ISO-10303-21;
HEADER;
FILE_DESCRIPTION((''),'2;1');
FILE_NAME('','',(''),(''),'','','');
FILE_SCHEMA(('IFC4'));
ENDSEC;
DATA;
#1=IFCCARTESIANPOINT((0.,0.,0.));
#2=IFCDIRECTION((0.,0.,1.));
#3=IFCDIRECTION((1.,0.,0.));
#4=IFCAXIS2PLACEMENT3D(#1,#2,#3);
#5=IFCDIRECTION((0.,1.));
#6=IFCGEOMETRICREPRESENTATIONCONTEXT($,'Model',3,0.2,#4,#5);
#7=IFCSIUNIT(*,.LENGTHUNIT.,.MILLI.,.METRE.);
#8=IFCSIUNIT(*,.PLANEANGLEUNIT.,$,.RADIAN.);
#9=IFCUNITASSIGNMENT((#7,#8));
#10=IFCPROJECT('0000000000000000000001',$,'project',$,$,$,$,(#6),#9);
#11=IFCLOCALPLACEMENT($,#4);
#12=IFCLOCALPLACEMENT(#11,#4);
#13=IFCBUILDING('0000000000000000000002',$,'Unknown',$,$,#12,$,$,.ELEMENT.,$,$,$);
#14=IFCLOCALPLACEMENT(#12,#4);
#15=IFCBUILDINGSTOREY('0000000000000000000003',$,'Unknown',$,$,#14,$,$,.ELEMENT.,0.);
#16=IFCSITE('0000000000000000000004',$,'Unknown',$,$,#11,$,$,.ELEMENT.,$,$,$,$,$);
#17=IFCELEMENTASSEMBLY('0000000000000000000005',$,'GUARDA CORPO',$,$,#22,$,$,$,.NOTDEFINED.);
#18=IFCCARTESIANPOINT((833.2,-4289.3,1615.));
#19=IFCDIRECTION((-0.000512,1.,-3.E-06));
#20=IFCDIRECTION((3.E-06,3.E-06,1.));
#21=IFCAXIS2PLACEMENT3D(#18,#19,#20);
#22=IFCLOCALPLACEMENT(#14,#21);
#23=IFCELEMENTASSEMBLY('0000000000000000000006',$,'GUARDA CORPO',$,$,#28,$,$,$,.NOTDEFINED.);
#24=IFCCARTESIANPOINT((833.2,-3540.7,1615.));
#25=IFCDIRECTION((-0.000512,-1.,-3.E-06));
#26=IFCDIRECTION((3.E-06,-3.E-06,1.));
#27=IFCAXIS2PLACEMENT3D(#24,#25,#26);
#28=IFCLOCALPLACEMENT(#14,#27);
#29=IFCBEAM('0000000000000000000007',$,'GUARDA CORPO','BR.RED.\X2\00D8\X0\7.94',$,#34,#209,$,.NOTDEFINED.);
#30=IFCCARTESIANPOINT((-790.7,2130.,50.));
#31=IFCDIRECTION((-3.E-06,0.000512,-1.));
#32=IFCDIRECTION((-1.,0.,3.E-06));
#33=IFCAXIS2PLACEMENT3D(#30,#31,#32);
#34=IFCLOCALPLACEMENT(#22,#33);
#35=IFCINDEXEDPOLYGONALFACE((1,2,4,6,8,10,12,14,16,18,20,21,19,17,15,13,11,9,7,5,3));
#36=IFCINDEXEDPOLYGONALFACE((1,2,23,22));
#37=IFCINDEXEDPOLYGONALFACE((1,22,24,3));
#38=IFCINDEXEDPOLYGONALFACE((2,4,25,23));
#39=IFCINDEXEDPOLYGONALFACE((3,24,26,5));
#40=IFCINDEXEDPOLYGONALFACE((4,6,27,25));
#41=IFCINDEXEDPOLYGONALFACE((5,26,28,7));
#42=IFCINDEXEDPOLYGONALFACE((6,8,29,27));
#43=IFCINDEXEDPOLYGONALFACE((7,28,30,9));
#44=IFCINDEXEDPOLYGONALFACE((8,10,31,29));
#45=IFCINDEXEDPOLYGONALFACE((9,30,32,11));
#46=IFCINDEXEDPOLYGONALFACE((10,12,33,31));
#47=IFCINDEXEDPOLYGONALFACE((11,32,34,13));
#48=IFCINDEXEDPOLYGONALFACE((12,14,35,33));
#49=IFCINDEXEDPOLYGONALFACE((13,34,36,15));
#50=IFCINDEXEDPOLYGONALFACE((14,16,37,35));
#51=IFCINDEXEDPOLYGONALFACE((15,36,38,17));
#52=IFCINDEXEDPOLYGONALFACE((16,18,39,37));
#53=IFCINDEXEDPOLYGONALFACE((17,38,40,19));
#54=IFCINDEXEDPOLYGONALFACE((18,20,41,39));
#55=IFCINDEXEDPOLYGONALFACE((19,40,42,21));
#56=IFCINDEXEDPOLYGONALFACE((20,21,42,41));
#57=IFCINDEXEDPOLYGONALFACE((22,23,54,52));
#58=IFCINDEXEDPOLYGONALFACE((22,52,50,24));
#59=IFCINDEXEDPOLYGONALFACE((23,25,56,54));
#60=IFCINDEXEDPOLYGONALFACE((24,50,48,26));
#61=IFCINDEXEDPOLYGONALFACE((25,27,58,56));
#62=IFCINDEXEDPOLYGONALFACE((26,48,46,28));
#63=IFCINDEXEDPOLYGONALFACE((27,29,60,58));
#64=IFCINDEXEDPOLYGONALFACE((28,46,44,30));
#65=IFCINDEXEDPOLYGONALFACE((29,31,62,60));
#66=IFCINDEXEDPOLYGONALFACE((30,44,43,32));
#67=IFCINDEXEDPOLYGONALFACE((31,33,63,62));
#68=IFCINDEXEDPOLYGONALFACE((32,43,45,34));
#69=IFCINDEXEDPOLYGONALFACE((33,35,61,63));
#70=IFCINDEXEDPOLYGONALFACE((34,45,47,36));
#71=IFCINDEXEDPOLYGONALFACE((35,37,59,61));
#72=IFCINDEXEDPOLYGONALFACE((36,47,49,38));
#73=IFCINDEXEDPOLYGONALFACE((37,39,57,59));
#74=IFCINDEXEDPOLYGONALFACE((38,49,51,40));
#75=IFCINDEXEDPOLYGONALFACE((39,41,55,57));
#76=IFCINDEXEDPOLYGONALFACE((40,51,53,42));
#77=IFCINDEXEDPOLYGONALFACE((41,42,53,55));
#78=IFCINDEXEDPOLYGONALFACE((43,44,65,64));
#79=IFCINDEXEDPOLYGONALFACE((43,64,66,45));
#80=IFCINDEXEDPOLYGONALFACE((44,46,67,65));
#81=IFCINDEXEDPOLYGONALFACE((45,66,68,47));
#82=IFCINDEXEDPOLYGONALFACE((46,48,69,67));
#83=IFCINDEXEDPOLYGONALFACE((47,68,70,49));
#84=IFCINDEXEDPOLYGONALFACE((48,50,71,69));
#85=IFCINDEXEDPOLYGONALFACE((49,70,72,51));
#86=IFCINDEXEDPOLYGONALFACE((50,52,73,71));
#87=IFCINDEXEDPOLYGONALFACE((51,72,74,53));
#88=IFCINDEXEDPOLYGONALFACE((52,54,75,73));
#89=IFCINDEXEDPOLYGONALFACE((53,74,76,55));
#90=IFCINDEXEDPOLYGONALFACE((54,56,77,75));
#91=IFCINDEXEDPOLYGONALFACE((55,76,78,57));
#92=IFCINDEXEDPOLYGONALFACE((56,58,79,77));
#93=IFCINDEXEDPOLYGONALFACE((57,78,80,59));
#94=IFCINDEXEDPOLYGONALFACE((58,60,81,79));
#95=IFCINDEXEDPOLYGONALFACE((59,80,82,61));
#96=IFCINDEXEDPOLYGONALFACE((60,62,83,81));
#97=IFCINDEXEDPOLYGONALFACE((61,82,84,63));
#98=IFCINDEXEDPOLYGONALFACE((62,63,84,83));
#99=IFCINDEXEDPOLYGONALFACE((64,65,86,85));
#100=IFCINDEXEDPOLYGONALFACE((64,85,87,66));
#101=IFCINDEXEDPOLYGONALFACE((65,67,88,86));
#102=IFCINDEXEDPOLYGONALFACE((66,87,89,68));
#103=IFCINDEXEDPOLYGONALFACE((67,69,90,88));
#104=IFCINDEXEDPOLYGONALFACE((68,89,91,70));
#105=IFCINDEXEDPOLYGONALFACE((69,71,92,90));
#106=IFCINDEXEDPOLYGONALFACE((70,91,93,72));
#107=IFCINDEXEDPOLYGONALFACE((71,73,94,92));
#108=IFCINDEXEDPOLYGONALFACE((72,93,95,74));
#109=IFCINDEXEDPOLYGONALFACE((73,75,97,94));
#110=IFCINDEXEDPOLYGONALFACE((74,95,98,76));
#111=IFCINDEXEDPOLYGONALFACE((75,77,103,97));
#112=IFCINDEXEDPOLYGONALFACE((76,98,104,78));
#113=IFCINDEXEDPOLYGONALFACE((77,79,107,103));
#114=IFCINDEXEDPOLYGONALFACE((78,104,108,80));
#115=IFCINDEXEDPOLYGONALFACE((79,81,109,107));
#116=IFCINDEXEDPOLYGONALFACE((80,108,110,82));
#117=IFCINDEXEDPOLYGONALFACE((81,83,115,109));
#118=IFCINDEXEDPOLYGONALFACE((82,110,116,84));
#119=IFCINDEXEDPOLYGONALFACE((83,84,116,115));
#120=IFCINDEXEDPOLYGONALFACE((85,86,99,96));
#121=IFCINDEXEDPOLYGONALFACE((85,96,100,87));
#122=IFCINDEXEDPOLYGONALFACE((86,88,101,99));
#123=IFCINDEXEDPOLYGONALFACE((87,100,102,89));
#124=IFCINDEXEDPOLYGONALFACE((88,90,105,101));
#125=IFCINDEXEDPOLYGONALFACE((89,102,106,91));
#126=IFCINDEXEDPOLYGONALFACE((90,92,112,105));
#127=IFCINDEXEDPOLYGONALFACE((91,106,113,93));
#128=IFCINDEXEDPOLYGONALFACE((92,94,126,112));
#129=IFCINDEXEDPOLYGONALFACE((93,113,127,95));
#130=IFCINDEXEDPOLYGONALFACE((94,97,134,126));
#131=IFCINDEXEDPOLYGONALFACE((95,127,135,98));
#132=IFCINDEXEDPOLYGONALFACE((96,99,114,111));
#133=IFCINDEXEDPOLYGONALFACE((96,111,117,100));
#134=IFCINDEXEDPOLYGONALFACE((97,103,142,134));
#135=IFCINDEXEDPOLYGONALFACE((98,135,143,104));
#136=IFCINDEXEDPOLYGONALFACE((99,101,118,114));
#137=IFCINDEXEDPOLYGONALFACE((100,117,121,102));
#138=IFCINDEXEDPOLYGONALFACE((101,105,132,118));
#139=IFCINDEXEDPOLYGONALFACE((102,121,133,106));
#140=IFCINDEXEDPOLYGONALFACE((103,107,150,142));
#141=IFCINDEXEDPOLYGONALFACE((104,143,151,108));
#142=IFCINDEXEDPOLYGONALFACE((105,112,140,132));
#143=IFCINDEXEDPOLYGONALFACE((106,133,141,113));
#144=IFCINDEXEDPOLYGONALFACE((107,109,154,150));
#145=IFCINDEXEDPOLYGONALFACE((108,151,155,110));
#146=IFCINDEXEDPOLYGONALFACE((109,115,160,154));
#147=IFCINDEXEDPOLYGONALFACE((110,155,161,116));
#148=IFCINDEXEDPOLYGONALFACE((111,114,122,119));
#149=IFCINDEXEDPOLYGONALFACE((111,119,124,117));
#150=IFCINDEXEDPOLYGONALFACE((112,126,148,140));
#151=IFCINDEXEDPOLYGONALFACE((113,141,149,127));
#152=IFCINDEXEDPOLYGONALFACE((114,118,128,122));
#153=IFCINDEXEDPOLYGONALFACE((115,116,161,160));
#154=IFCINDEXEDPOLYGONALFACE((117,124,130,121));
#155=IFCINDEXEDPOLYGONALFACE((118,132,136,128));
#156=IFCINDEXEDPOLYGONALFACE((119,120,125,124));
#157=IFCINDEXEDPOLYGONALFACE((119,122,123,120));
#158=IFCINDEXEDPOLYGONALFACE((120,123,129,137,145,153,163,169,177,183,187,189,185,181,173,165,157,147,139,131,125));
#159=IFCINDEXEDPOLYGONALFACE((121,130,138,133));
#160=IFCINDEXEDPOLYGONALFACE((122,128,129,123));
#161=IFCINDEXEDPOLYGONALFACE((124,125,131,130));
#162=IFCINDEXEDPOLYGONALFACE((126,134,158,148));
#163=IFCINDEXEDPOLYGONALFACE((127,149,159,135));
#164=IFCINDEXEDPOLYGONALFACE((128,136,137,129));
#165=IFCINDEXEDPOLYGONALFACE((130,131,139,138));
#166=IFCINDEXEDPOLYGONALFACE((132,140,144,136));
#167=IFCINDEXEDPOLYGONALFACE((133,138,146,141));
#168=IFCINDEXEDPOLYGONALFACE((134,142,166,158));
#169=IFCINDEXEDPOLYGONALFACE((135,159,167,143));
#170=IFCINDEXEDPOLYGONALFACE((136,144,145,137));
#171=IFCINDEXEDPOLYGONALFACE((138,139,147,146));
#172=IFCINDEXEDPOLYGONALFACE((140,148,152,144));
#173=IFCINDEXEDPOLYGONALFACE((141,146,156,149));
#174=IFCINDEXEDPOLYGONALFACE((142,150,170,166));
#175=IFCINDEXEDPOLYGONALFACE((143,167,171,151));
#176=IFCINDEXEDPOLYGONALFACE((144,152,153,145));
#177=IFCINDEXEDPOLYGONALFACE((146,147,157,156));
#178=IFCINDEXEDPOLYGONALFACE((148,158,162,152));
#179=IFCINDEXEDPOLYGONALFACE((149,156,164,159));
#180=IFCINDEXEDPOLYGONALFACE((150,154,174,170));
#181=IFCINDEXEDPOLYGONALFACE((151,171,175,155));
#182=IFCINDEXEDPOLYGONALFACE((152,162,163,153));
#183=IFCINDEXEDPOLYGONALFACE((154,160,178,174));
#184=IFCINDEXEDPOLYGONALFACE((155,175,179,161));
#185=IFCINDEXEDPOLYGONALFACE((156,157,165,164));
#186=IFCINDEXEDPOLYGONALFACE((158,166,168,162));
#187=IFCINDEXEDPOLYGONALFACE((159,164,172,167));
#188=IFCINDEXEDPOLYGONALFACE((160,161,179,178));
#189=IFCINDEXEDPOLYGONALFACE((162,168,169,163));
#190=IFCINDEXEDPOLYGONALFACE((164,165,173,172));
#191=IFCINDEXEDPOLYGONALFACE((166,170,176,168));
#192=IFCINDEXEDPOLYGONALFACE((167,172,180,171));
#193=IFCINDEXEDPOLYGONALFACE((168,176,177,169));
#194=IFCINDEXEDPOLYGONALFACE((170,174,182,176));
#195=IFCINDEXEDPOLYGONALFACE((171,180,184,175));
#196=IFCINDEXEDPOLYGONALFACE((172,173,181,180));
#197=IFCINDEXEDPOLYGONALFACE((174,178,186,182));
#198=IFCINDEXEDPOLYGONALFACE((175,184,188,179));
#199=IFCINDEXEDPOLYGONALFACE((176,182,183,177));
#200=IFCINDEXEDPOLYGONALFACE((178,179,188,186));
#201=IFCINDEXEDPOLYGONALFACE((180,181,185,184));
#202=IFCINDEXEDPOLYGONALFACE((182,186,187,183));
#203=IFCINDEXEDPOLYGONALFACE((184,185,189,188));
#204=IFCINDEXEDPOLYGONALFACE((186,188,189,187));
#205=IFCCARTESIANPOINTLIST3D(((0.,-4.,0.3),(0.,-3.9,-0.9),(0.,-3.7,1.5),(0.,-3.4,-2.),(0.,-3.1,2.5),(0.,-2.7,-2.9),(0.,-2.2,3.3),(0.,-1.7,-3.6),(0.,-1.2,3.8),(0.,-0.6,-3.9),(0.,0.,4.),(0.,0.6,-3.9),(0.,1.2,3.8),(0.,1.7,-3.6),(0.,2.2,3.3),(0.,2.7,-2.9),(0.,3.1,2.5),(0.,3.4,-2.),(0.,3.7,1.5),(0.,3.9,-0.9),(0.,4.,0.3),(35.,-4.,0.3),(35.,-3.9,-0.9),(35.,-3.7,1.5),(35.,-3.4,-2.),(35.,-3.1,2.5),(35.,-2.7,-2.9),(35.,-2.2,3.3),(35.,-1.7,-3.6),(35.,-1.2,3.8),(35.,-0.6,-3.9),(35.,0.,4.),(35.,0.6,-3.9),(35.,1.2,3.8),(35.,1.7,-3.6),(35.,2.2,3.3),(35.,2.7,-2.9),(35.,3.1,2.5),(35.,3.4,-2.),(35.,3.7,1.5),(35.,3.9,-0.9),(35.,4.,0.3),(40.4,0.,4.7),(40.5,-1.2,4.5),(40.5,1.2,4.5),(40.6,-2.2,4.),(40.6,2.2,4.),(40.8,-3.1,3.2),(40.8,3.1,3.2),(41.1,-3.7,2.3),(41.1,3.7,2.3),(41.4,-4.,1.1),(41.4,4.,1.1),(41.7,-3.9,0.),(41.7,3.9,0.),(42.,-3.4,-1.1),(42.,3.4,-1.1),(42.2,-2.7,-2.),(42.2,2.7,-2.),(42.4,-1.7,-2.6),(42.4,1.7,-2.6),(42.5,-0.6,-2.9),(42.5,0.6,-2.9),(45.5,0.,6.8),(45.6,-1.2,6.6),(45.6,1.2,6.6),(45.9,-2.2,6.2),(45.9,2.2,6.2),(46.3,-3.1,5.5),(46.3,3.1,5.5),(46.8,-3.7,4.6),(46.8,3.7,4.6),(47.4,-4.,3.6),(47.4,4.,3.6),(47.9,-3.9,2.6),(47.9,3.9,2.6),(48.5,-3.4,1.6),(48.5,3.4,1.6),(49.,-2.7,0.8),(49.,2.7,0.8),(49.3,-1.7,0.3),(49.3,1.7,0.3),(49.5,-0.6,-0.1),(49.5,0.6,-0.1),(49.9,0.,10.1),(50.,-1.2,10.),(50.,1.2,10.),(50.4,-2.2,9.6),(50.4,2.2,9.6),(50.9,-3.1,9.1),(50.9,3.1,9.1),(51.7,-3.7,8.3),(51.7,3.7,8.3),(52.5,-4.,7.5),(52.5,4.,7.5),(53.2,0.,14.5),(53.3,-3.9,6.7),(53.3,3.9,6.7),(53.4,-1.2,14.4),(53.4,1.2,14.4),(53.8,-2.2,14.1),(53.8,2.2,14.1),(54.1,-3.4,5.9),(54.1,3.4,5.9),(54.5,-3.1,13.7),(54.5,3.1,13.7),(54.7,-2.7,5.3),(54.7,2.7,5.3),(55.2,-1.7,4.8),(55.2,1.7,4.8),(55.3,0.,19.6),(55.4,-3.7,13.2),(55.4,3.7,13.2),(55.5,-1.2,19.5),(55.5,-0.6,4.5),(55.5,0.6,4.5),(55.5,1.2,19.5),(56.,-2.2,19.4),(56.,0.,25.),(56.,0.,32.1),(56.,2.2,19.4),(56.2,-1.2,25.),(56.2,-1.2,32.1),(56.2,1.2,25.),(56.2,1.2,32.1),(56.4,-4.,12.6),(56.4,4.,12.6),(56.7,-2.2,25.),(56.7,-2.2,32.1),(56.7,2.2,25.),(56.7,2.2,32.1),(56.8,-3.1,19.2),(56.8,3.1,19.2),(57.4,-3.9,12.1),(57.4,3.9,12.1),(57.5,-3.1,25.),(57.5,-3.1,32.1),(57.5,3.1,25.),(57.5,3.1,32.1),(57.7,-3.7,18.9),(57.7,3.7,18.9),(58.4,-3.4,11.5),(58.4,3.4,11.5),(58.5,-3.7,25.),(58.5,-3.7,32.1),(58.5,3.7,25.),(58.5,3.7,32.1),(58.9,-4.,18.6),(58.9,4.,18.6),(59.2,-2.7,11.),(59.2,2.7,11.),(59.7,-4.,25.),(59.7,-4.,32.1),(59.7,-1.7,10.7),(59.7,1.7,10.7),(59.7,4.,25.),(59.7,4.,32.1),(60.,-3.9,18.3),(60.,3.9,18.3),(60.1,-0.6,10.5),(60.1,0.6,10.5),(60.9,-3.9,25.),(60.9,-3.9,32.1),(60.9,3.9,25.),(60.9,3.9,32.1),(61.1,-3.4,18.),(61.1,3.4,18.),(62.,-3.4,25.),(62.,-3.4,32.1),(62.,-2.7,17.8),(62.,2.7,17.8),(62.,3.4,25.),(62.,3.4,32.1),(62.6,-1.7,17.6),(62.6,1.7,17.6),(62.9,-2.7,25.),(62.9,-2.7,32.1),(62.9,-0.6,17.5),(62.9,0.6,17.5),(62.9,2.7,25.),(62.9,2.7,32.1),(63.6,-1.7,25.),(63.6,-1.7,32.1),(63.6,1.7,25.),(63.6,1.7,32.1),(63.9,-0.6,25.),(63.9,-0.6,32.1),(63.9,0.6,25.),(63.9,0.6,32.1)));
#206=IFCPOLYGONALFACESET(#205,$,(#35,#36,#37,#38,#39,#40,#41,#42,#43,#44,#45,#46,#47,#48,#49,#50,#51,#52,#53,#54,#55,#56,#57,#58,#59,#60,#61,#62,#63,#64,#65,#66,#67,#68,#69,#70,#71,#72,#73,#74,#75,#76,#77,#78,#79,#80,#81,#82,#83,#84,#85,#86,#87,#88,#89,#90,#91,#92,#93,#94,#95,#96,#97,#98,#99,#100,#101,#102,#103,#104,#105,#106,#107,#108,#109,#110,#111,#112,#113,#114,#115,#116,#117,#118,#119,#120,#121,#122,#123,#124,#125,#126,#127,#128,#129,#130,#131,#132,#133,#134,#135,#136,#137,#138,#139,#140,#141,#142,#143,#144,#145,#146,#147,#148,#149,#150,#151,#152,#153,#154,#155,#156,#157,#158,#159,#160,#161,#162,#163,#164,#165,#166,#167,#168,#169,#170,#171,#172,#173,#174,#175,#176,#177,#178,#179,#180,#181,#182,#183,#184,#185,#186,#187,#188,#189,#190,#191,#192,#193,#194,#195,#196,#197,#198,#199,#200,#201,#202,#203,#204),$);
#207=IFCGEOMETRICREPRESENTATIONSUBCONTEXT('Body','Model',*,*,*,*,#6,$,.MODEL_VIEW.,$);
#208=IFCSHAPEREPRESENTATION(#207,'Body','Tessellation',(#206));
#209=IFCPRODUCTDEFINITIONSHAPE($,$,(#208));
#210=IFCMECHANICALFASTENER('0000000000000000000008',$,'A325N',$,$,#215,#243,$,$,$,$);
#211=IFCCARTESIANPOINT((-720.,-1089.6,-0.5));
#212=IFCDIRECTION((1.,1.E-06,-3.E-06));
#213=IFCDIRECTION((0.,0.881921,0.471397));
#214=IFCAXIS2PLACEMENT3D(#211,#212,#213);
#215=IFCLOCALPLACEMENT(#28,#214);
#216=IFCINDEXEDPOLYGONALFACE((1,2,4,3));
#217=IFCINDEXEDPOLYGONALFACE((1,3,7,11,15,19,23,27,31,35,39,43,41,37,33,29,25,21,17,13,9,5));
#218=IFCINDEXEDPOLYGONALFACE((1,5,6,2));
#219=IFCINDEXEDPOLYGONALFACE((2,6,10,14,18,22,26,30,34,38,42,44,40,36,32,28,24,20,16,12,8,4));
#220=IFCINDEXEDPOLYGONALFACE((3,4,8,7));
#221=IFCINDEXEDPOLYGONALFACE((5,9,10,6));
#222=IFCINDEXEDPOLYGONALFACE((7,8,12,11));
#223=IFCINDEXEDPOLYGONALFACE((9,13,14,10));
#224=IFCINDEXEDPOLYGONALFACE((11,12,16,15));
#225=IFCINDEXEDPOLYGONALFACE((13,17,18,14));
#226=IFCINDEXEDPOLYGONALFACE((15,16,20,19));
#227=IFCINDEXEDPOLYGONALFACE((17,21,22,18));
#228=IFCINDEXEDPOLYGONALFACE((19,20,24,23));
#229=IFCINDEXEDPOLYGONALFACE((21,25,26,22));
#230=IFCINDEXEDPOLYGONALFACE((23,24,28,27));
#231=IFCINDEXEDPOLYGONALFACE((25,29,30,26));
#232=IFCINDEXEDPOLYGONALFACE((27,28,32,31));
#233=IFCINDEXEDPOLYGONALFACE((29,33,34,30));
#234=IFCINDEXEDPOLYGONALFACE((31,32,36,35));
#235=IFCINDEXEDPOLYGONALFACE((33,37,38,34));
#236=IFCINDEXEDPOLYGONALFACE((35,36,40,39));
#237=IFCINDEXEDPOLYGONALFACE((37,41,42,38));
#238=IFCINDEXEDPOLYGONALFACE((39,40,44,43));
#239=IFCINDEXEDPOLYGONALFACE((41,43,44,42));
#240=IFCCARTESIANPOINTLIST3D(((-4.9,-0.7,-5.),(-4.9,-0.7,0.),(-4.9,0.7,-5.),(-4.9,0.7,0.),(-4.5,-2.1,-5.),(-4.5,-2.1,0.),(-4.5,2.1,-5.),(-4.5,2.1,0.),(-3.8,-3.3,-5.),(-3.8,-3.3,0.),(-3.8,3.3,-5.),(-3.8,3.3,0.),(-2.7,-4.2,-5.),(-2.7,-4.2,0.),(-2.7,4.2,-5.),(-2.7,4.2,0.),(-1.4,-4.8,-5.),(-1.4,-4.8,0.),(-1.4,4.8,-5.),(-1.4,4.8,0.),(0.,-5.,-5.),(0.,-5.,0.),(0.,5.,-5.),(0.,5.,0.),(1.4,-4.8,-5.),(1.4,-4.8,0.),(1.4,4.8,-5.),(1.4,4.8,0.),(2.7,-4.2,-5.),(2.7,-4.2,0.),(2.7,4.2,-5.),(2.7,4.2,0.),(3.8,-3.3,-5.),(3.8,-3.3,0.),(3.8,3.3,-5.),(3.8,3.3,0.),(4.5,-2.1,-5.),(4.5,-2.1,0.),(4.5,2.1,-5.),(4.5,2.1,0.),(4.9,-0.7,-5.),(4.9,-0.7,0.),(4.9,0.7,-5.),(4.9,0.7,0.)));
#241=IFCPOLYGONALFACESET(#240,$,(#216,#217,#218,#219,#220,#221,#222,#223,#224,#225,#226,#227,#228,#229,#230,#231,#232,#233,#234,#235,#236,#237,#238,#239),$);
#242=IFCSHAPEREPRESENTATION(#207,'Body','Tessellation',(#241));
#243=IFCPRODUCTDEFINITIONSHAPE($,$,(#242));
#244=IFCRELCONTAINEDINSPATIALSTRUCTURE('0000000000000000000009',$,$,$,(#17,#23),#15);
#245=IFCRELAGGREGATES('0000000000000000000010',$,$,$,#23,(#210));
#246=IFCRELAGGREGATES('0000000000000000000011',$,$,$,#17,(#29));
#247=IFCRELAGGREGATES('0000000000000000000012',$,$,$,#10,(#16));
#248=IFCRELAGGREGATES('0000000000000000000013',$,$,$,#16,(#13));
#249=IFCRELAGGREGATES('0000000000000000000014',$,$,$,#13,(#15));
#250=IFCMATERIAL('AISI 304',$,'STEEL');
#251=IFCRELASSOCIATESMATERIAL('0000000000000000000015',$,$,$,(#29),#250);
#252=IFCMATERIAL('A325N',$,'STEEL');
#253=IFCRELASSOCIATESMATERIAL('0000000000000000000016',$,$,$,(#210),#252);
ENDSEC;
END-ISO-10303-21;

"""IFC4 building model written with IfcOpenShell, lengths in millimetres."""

from ifc_helpers import new_model, entity, si_unit, direction, frame, origin_with_axes, place, context, subcontext, project, spatial, arc, indexed_curve, outline, extrude, source, transform, mapped, material, element, aggregate, save


model = new_model("IFC4")

# Units and contexts
model_context = context("Model", 3, precision=0.2, world=origin_with_axes(), true_north=direction((0.0, 1.0)))
body_context = subcontext(model_context, "Body", "Model", "MODEL_VIEW")
ifc_project = project(units=[si_unit("LENGTHUNIT", "METRE", prefix="MILLI"), si_unit("PLANEANGLEUNIT", "RADIAN")], contexts=[model_context])

# Site, building, storey
site_placement = place(None, origin_with_axes())
site = spatial("IfcSite", under=ifc_project, at=site_placement, Name="Unknown", CompositionType="ELEMENT")
building_placement = place(site_placement, origin_with_axes())
building = spatial("IfcBuilding", under=site, at=building_placement, Name="Unknown", CompositionType="ELEMENT")
storey_placement = place(building_placement, origin_with_axes())
storey = spatial("IfcBuildingStorey", under=building, at=storey_placement, Name="Unknown", CompositionType="ELEMENT", Elevation=0.0)

# Element assembly
assembly_1_placement = place(storey_placement, frame((833.2, -4289.3, 1615.0), z_axis=(-0.000512, 1.0, -0.000003), x_axis=(0.000003, 0.000003, 1.0)))
assembly_1 = element("IfcElementAssembly", 1, at=assembly_1_placement, inside=storey, Name="GUARDA CORPO", PredefinedType="NOTDEFINED")
ifc_material_1 = material(Name="AISI 304", Category="STEEL")

# Element assembly
assembly_2_placement = place(storey_placement, frame((833.2, -3540.7, 1615.0), z_axis=(-0.000512, -1.0, -0.000003), x_axis=(0.000003, -0.000003, 1.0)))
assembly_2 = element("IfcElementAssembly", 2, at=assembly_2_placement, inside=storey, Name="GUARDA CORPO", PredefinedType="NOTDEFINED")

# Beam
beam_1_placement = place(assembly_1_placement, frame((-790.7, 2130.0, 50.0), z_axis=(-0.000003, 0.000512, -1.0), x_axis=(-1.0, 0.0, 0.000003)))
beam_1 = element("IfcBeam", 3, at=beam_1_placement, material=ifc_material_1, Name="GUARDA CORPO", Description="BR.RED.Ø7.94", PredefinedType="NOTDEFINED", context=body_context, shape_type="SolidModel", body=[
    entity("IfcSweptDiskSolid", entity("IfcIndexedPolyCurve", entity("IfcCartesianPointList3D", [[0.0, 0.0, 0.0], [35.0, 0.0, 0.0], [52.7, 0.0, 7.3], [60.0, 0.0, 25.0], [60.0, 0.0, 32.1]]), [entity("IfcLineIndex", [1, 2]), entity("IfcArcIndex", [2, 3, 4]), entity("IfcLineIndex", [4, 5])]), 4.0),
])

# Shared definitions
ifc_material_2 = material(Name="A325N", Category="STEEL")

# Mechanical fastener
shared_shape_1 = source(origin_with_axes(), body_context, "Body", "SweptSolid", [
    extrude(outline(indexed_curve([(5.0, 0.0), (0.0, 5.0), (-5.0, 0.0), (0.0, -5.0)], segments=[arc(1, 2, 3), arc(3, 4, 1)])), frame((0.0, 0.0, 0.0), z_axis=(0.0, 0.0, -1.0), x_axis=(0.0, 1.0, 0.0)), (0.0, 0.0, 1.0), 5.0),
])
mechanical_fastener_1_placement = place(assembly_2_placement, frame((-720.0, -1089.6, -0.5), z_axis=(1.0, 0.000001, -0.000003), x_axis=(0.0, 0.881921, 0.471397)))
mechanical_fastener_1 = element("IfcMechanicalFastener", 4, at=mechanical_fastener_1_placement, material=ifc_material_2, Name="A325N", context=body_context, shape_type="MappedRepresentation", body=[
    mapped(shared_shape_1, transform((0.0, 0.0, 0.0))),
])
aggregate(assembly_2, [mechanical_fastener_1])
aggregate(assembly_1, [beam_1])

save(model, "model.ifc")
